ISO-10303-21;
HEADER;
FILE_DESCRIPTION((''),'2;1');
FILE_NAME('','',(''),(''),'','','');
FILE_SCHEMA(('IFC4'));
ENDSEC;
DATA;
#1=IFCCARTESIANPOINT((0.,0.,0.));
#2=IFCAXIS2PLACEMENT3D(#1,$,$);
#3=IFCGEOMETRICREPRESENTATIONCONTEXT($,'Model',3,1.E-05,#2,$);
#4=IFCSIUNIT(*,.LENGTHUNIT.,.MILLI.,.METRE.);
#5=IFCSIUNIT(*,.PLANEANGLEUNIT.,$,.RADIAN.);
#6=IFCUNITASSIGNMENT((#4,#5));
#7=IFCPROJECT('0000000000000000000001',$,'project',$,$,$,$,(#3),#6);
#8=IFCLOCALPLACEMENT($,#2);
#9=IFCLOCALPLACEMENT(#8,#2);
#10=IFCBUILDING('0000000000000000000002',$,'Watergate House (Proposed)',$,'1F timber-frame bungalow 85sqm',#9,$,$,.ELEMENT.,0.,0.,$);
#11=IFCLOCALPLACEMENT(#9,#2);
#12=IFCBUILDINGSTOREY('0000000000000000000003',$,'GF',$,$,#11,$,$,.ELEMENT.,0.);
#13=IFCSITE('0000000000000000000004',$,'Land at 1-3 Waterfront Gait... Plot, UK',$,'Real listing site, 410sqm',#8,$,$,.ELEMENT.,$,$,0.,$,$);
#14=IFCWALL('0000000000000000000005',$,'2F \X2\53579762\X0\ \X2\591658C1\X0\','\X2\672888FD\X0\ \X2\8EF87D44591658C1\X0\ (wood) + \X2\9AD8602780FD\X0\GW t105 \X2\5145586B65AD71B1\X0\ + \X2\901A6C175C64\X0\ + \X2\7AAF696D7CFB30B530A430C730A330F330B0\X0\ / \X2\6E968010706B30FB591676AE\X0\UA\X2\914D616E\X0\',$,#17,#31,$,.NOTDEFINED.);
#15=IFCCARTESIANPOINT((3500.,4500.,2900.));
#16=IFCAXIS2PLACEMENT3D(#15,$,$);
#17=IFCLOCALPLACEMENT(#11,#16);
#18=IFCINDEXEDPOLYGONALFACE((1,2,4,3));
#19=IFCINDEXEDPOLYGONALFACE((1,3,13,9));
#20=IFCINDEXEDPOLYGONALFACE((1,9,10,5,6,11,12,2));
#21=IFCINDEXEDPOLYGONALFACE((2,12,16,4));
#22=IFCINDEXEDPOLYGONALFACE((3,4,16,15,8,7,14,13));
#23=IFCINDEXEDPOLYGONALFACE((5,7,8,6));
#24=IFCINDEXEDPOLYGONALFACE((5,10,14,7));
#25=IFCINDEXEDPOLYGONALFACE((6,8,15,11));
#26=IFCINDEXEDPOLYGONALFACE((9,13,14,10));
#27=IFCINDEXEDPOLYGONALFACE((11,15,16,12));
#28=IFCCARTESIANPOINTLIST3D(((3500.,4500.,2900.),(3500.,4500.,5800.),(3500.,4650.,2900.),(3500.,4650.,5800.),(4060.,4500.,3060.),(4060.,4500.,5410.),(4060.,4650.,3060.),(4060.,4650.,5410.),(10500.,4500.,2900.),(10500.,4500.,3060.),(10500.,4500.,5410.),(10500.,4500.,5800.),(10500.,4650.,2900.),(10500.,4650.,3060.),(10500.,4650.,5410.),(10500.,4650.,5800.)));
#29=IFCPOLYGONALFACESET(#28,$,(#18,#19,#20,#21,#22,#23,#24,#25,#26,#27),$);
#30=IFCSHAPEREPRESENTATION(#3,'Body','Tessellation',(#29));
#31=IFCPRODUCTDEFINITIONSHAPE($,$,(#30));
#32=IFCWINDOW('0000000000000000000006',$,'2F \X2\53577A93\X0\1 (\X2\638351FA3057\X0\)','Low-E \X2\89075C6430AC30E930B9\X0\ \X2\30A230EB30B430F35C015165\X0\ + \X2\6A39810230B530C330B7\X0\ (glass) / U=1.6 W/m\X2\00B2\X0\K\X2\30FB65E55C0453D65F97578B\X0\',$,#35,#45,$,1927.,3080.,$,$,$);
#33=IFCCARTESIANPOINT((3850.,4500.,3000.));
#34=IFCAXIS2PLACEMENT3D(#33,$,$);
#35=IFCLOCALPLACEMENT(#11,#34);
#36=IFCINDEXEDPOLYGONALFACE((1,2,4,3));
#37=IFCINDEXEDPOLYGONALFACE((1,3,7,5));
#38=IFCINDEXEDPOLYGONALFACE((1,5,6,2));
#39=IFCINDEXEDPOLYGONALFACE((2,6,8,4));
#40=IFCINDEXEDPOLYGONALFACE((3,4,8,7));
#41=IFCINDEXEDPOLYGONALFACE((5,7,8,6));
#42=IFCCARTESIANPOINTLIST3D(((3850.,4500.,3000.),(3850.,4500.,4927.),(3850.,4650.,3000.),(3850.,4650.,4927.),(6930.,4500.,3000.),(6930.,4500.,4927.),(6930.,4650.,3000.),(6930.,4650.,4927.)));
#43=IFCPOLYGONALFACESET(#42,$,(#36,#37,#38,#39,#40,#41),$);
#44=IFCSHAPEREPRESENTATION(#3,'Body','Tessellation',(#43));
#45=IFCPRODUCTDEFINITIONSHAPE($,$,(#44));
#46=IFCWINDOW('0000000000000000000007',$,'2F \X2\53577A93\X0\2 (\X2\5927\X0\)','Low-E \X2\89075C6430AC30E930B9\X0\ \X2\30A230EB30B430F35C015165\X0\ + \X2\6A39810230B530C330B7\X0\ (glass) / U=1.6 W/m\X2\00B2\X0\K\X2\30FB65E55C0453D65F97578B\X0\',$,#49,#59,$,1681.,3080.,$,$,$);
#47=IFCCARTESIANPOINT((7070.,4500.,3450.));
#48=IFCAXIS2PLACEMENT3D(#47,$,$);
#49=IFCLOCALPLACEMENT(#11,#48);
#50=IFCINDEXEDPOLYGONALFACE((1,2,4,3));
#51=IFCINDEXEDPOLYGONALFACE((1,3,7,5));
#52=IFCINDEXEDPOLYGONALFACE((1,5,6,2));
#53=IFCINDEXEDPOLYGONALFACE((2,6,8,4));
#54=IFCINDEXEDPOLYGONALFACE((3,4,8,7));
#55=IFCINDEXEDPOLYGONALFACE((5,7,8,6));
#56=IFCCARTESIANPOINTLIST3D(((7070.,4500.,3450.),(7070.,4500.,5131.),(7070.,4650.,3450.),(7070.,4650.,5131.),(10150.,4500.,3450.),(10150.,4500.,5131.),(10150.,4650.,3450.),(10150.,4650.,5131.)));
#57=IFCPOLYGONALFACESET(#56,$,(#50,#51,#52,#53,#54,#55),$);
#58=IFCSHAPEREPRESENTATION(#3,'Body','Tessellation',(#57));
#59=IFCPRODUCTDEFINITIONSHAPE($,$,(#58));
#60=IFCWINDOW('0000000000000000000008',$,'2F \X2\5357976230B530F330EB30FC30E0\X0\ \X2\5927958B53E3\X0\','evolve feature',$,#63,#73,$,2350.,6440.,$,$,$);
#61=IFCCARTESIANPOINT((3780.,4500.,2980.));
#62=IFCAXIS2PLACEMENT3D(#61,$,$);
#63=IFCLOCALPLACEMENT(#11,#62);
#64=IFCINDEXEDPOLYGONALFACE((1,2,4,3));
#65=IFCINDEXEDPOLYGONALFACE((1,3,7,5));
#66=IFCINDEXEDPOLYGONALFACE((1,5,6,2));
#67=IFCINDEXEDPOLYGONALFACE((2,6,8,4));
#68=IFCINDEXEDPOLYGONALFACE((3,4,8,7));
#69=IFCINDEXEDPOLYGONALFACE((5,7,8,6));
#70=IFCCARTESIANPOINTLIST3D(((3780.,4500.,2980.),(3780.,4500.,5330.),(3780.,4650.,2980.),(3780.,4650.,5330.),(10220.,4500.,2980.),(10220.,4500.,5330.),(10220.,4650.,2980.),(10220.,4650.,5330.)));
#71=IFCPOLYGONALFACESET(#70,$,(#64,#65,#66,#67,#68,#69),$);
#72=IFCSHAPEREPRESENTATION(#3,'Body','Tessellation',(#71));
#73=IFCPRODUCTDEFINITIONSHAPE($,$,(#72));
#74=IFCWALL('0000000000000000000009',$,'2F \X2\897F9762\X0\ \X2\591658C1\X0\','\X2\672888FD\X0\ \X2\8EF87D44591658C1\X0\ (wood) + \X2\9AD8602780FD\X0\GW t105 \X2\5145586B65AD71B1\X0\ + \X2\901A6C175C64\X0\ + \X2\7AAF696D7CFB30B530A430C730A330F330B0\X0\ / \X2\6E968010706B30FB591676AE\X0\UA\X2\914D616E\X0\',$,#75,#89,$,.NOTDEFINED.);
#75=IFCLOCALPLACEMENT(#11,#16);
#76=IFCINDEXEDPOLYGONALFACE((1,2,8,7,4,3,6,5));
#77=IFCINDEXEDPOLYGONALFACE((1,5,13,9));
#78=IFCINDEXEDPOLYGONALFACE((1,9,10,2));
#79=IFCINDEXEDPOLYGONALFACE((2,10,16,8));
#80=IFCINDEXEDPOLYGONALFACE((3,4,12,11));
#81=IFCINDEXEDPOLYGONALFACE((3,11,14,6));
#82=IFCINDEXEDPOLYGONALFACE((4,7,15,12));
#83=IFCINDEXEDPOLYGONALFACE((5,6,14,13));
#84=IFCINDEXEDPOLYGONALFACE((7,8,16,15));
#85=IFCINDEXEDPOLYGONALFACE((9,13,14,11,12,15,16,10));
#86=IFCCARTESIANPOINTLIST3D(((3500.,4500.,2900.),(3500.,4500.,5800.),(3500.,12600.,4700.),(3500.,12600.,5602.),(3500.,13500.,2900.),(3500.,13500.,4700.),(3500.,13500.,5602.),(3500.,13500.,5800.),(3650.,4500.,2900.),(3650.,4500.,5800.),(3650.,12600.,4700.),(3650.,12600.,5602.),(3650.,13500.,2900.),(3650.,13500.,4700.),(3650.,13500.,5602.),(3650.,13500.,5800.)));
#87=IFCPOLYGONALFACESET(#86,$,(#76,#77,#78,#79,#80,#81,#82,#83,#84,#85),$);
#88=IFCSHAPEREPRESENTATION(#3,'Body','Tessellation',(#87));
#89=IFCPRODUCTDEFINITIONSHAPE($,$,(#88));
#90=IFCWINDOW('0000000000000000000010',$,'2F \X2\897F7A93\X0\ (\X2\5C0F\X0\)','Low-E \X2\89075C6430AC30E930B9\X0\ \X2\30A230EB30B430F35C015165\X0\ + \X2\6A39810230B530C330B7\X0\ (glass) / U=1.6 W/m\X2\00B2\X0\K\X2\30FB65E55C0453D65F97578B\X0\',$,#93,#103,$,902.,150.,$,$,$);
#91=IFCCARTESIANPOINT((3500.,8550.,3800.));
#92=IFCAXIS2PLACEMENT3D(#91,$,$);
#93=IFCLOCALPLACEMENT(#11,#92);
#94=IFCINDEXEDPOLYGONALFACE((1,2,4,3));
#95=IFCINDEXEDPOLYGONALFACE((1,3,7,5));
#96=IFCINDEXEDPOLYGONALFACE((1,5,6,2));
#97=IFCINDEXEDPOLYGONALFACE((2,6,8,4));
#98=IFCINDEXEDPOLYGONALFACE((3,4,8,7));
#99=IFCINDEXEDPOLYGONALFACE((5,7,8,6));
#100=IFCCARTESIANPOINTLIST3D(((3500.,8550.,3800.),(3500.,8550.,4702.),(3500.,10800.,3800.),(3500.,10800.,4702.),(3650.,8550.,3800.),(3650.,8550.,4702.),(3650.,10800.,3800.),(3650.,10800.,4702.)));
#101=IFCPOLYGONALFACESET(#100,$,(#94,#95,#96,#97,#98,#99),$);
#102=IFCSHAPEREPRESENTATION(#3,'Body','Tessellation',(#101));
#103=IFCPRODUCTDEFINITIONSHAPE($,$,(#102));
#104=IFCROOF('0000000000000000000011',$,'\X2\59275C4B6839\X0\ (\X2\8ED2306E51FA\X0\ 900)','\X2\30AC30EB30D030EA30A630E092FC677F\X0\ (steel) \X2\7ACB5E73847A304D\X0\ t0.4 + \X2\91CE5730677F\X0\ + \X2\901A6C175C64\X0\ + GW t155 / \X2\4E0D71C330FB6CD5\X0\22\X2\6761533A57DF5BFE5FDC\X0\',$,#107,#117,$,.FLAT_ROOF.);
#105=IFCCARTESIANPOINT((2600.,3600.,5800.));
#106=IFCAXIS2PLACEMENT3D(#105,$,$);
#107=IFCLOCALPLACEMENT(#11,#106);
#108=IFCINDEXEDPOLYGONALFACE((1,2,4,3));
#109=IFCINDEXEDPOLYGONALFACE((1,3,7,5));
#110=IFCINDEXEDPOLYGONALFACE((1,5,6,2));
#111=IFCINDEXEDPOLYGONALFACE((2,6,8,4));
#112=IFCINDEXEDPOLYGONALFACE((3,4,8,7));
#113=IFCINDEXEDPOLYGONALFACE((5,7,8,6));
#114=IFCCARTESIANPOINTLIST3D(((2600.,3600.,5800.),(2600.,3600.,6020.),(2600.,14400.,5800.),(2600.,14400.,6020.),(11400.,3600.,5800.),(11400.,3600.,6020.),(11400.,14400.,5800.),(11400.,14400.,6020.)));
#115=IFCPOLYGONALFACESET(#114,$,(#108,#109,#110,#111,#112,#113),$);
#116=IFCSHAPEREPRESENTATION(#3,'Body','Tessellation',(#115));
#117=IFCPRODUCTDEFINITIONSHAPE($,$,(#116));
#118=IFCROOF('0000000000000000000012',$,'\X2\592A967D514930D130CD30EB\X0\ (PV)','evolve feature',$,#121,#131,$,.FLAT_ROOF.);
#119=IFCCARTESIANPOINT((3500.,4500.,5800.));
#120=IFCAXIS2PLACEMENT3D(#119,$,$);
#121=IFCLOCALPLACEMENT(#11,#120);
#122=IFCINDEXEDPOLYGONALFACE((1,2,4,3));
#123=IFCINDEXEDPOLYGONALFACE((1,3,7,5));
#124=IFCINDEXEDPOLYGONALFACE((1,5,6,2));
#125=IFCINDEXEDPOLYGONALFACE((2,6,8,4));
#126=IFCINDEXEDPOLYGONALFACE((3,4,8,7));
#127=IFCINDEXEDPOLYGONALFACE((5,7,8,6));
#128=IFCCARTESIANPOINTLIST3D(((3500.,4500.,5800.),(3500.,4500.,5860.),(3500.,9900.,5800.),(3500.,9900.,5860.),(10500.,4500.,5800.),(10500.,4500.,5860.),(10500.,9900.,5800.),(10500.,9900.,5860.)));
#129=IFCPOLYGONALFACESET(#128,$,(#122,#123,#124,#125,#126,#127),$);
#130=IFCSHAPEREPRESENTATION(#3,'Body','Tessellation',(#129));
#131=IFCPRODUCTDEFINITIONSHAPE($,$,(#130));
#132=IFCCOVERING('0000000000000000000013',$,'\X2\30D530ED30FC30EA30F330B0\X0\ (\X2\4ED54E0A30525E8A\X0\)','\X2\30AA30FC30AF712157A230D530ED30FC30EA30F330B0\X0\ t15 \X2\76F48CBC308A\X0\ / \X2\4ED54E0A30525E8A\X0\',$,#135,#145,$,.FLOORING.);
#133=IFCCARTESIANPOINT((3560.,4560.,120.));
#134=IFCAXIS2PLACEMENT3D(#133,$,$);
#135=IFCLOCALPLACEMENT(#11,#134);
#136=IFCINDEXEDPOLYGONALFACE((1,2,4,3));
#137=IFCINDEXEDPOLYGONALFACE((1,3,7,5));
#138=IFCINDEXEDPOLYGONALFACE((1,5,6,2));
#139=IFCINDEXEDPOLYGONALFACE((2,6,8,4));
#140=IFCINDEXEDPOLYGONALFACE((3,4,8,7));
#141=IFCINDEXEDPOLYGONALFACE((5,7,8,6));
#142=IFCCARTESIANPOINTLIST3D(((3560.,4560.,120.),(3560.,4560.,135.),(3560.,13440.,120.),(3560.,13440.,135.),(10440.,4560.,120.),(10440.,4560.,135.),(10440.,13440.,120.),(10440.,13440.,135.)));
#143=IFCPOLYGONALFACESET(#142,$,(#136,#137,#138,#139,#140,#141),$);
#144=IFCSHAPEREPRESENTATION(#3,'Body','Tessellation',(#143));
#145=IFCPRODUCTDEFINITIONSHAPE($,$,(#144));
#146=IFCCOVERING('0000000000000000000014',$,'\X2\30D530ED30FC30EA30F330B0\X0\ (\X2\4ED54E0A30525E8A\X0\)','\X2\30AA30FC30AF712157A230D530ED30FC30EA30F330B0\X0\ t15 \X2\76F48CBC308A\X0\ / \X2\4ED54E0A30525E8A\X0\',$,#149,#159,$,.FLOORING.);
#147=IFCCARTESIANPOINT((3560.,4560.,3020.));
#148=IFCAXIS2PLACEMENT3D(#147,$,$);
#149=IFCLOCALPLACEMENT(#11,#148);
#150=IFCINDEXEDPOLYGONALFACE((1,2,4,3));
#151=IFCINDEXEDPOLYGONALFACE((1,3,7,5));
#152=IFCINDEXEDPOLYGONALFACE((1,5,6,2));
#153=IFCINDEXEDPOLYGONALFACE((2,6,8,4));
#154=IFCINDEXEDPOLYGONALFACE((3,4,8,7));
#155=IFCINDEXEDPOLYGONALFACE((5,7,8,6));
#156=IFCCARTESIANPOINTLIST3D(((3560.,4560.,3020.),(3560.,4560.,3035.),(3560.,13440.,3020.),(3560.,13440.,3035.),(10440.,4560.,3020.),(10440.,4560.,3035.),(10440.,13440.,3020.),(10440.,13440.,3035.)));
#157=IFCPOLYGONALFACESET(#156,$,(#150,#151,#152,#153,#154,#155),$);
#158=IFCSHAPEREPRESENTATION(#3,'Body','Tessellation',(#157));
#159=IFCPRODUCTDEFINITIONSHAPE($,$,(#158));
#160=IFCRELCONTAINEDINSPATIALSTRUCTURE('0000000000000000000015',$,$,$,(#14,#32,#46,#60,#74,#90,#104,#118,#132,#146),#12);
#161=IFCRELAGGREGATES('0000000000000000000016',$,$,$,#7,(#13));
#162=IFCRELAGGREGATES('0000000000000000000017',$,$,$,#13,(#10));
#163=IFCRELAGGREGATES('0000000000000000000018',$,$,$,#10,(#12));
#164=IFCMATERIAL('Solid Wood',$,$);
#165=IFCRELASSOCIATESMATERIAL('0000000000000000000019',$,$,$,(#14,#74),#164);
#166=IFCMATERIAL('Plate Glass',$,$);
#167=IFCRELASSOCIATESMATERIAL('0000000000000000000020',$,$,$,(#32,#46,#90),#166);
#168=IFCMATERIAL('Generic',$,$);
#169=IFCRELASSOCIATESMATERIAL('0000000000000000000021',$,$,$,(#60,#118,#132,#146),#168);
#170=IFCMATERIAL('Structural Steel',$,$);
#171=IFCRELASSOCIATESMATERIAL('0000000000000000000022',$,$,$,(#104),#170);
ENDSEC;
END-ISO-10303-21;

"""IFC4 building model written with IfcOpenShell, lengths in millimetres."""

from ifc_helpers import new_model, si_unit, frame, frame_2d, origin, place, context, project, spatial, rectangle, extrude, material, element, fill, save


model = new_model("IFC4")

# Units and contexts
model_context = context("Model", 3, precision=1e-05, world=origin())
ifc_project = project(units=[si_unit("LENGTHUNIT", "METRE", prefix="MILLI"), si_unit("PLANEANGLEUNIT", "RADIAN")], contexts=[model_context])

# Site, building, storey
site_placement = place(None, origin())
site = spatial("IfcSite", under=ifc_project, at=site_placement, Name="Land at 1-3 Waterfront Gait... Plot, UK", ObjectType="Real listing site, 410sqm", CompositionType="ELEMENT", RefElevation=0.0)
building_placement = place(site_placement, origin())
building = spatial("IfcBuilding", under=site, at=building_placement, Name="Watergate House (Proposed)", ObjectType="1F timber-frame bungalow 85sqm", CompositionType="ELEMENT", ElevationOfRefHeight=0.0, ElevationOfTerrain=0.0)
storey_placement = place(building_placement, origin())
storey = spatial("IfcBuildingStorey", under=building, at=storey_placement, Name="GF", CompositionType="ELEMENT", Elevation=0.0)

# Shared definitions
ifc_material_1 = material(Name="Solid Wood")
ifc_material_2 = material(Name="Generic")

# Shared definitions
ifc_material_3 = material(Name="Plate Glass")

# Wall, openings, windows
wall_1_placement = place(storey_placement, frame((3500.0, 4500.0, 2900.0)))
wall_1 = element("IfcWall", 1, at=wall_1_placement, inside=storey, material=ifc_material_1, Name="2F 南面 外壁", Description="木製 軸組外壁 (wood) + 高性能GW t105 充填断熱 + 通気層 + 窯業系サイディング / 準耐火・外皮UA配慮", PredefinedType="NOTDEFINED", context=model_context, shape_type="SweptSolid", body=[
    extrude(rectangle(XDim=7000.0, YDim=150.0, at=frame_2d((3500.0, 75.0))), frame((3500.0, 4500.0, 2900.0)), (0.0, 0.0, 1.0), 2900.0),
])
opening_1_placement = place(storey_placement, frame((3850.0, 4500.0, 3000.0)))
opening_1 = element("IfcOpeningElement", 2, at=opening_1_placement, cuts=wall_1, PredefinedType="NOTDEFINED", context=model_context, shape_type="SweptSolid", body=[
    extrude(rectangle(XDim=3080.0, YDim=150.0, at=frame_2d((1540.0, 75.0))), frame((3850.0, 4500.0, 3000.0)), (0.0, 0.0, 1.0), 1927.0),
])
opening_2_placement = place(storey_placement, frame((7070.0, 4500.0, 3450.0)))
opening_2 = element("IfcOpeningElement", 3, at=opening_2_placement, cuts=wall_1, PredefinedType="NOTDEFINED", context=model_context, shape_type="SweptSolid", body=[
    extrude(rectangle(XDim=3080.0, YDim=150.0, at=frame_2d((1540.0, 75.0))), frame((7070.0, 4500.0, 3450.0)), (0.0, 0.0, 1.0), 1681.0),
])
opening_3_placement = place(storey_placement, frame((3780.0, 4500.0, 2980.0)))
opening_3 = element("IfcOpeningElement", 4, at=opening_3_placement, cuts=wall_1, PredefinedType="NOTDEFINED", context=model_context, shape_type="SweptSolid", body=[
    extrude(rectangle(XDim=6440.0, YDim=150.0, at=frame_2d((3220.0, 75.0))), frame((3780.0, 4500.0, 2980.0)), (0.0, 0.0, 1.0), 2350.0),
])
window_1_placement = place(storey_placement, frame((3850.0, 4500.0, 3000.0)))
window_1 = element("IfcWindow", 5, at=window_1_placement, inside=storey, material=ifc_material_3, Name="2F 南窓1 (掃出し)", Description="Low-E 複層ガラス アルゴン封入 + 樹脂サッシ (glass) / U=1.6 W/m²K・日射取得型", OverallHeight=1927.0, OverallWidth=3080.0, context=model_context, shape_type="SweptSolid", body=[
    extrude(rectangle(XDim=3080.0, YDim=150.0, at=frame_2d((1540.0, 75.0))), frame((3850.0, 4500.0, 3000.0)), (0.0, 0.0, 1.0), 1927.0),
])
fill(opening_1, window_1)
window_2_placement = place(storey_placement, frame((7070.0, 4500.0, 3450.0)))
window_2 = element("IfcWindow", 6, at=window_2_placement, inside=storey, material=ifc_material_3, Name="2F 南窓2 (大)", Description="Low-E 複層ガラス アルゴン封入 + 樹脂サッシ (glass) / U=1.6 W/m²K・日射取得型", OverallHeight=1681.0, OverallWidth=3080.0, context=model_context, shape_type="SweptSolid", body=[
    extrude(rectangle(XDim=3080.0, YDim=150.0, at=frame_2d((1540.0, 75.0))), frame((7070.0, 4500.0, 3450.0)), (0.0, 0.0, 1.0), 1681.0),
])
fill(opening_2, window_2)
window_3_placement = place(storey_placement, frame((3780.0, 4500.0, 2980.0)))
window_3 = element("IfcWindow", 7, at=window_3_placement, inside=storey, material=ifc_material_2, Name="2F 南面サンルーム 大開口", Description="evolve feature", OverallHeight=2350.0, OverallWidth=6440.0, context=model_context, shape_type="SweptSolid", body=[
    extrude(rectangle(XDim=6440.0, YDim=150.0, at=frame_2d((3220.0, 75.0))), frame((3780.0, 4500.0, 2980.0)), (0.0, 0.0, 1.0), 2350.0),
])
fill(opening_3, window_3)

# Wall, opening, window
wall_2_placement = place(storey_placement, frame((3500.0, 4500.0, 2900.0)))
wall_2 = element("IfcWall", 8, at=wall_2_placement, inside=storey, material=ifc_material_1, Name="2F 西面 外壁", Description="木製 軸組外壁 (wood) + 高性能GW t105 充填断熱 + 通気層 + 窯業系サイディング / 準耐火・外皮UA配慮", PredefinedType="NOTDEFINED", context=model_context, shape_type="SweptSolid", body=[
    extrude(rectangle(XDim=150.0, YDim=9000.0, at=frame_2d((75.0, 4500.0))), frame((3500.0, 4500.0, 2900.0)), (0.0, 0.0, 1.0), 2900.0),
])
opening_4_placement = place(storey_placement, frame((3500.0, 8550.0, 3800.0)))
opening_4 = element("IfcOpeningElement", 9, at=opening_4_placement, cuts=wall_2, PredefinedType="NOTDEFINED", context=model_context, shape_type="SweptSolid", body=[
    extrude(rectangle(XDim=150.0, YDim=2250.0, at=frame_2d((75.0, 1125.0))), frame((3500.0, 8550.0, 3800.0)), (0.0, 0.0, 1.0), 902.0),
])
window_4_placement = place(storey_placement, frame((3500.0, 8550.0, 3800.0)))
window_4 = element("IfcWindow", 10, at=window_4_placement, inside=storey, material=ifc_material_3, Name="2F 西窓 (小)", Description="Low-E 複層ガラス アルゴン封入 + 樹脂サッシ (glass) / U=1.6 W/m²K・日射取得型", OverallHeight=902.0, OverallWidth=150.0, context=model_context, shape_type="SweptSolid", body=[
    extrude(rectangle(XDim=150.0, YDim=2250.0, at=frame_2d((75.0, 1125.0))), frame((3500.0, 8550.0, 3800.0)), (0.0, 0.0, 1.0), 902.0),
])
fill(opening_4, window_4)

# Roofs
ifc_material_4 = material(Name="Structural Steel")
roof_1_placement = place(storey_placement, frame((2600.0, 3600.0, 5800.0)))
element("IfcRoof", 11, at=roof_1_placement, inside=storey, material=ifc_material_4, Name="大屋根 (軒の出 900)", Description="ガルバリウム鋼板 (steel) 立平葺き t0.4 + 野地板 + 通気層 + GW t155 / 不燃・法22条区域対応", PredefinedType="FLAT_ROOF", context=model_context, shape_type="SweptSolid", body=[
    extrude(rectangle(XDim=8800.0, YDim=10800.0, at=frame_2d((4400.0, 5400.0))), frame((2600.0, 3600.0, 5800.0)), (0.0, 0.0, 1.0), 220.0),
])
roof_2_placement = place(storey_placement, frame((3500.0, 4500.0, 5800.0)))
element("IfcRoof", 12, at=roof_2_placement, inside=storey, material=ifc_material_2, Name="太陽光パネル (PV)", Description="evolve feature", PredefinedType="FLAT_ROOF", context=model_context, shape_type="SweptSolid", body=[
    extrude(rectangle(XDim=7000.0, YDim=5400.0, at=frame_2d((3500.0, 2700.0))), frame((3500.0, 4500.0, 5800.0)), (0.0, 0.0, 1.0), 60.0),
])

# Coverings
covering_1_placement = place(storey_placement, frame((3560.0, 4560.0, 120.0)))
element("IfcCovering", 13, at=covering_1_placement, inside=storey, material=ifc_material_2, Name="フローリング (仕上げ床)", Description="オーク無垢フローリング t15 直貼り / 仕上げ床", PredefinedType="FLOORING", context=model_context, shape_type="SweptSolid", body=[
    extrude(rectangle(XDim=6880.0, YDim=8880.0, at=frame_2d((3440.0, 4440.0))), frame((3560.0, 4560.0, 120.0)), (0.0, 0.0, 1.0), 15.0),
])
covering_2_placement = place(storey_placement, frame((3560.0, 4560.0, 3020.0)))
element("IfcCovering", 14, at=covering_2_placement, inside=storey, material=ifc_material_2, Name="フローリング (仕上げ床)", Description="オーク無垢フローリング t15 直貼り / 仕上げ床", PredefinedType="FLOORING", context=model_context, shape_type="SweptSolid", body=[
    extrude(rectangle(XDim=6880.0, YDim=8880.0, at=frame_2d((3440.0, 4440.0))), frame((3560.0, 4560.0, 3020.0)), (0.0, 0.0, 1.0), 15.0),
])

save(model, "model.ifc")
